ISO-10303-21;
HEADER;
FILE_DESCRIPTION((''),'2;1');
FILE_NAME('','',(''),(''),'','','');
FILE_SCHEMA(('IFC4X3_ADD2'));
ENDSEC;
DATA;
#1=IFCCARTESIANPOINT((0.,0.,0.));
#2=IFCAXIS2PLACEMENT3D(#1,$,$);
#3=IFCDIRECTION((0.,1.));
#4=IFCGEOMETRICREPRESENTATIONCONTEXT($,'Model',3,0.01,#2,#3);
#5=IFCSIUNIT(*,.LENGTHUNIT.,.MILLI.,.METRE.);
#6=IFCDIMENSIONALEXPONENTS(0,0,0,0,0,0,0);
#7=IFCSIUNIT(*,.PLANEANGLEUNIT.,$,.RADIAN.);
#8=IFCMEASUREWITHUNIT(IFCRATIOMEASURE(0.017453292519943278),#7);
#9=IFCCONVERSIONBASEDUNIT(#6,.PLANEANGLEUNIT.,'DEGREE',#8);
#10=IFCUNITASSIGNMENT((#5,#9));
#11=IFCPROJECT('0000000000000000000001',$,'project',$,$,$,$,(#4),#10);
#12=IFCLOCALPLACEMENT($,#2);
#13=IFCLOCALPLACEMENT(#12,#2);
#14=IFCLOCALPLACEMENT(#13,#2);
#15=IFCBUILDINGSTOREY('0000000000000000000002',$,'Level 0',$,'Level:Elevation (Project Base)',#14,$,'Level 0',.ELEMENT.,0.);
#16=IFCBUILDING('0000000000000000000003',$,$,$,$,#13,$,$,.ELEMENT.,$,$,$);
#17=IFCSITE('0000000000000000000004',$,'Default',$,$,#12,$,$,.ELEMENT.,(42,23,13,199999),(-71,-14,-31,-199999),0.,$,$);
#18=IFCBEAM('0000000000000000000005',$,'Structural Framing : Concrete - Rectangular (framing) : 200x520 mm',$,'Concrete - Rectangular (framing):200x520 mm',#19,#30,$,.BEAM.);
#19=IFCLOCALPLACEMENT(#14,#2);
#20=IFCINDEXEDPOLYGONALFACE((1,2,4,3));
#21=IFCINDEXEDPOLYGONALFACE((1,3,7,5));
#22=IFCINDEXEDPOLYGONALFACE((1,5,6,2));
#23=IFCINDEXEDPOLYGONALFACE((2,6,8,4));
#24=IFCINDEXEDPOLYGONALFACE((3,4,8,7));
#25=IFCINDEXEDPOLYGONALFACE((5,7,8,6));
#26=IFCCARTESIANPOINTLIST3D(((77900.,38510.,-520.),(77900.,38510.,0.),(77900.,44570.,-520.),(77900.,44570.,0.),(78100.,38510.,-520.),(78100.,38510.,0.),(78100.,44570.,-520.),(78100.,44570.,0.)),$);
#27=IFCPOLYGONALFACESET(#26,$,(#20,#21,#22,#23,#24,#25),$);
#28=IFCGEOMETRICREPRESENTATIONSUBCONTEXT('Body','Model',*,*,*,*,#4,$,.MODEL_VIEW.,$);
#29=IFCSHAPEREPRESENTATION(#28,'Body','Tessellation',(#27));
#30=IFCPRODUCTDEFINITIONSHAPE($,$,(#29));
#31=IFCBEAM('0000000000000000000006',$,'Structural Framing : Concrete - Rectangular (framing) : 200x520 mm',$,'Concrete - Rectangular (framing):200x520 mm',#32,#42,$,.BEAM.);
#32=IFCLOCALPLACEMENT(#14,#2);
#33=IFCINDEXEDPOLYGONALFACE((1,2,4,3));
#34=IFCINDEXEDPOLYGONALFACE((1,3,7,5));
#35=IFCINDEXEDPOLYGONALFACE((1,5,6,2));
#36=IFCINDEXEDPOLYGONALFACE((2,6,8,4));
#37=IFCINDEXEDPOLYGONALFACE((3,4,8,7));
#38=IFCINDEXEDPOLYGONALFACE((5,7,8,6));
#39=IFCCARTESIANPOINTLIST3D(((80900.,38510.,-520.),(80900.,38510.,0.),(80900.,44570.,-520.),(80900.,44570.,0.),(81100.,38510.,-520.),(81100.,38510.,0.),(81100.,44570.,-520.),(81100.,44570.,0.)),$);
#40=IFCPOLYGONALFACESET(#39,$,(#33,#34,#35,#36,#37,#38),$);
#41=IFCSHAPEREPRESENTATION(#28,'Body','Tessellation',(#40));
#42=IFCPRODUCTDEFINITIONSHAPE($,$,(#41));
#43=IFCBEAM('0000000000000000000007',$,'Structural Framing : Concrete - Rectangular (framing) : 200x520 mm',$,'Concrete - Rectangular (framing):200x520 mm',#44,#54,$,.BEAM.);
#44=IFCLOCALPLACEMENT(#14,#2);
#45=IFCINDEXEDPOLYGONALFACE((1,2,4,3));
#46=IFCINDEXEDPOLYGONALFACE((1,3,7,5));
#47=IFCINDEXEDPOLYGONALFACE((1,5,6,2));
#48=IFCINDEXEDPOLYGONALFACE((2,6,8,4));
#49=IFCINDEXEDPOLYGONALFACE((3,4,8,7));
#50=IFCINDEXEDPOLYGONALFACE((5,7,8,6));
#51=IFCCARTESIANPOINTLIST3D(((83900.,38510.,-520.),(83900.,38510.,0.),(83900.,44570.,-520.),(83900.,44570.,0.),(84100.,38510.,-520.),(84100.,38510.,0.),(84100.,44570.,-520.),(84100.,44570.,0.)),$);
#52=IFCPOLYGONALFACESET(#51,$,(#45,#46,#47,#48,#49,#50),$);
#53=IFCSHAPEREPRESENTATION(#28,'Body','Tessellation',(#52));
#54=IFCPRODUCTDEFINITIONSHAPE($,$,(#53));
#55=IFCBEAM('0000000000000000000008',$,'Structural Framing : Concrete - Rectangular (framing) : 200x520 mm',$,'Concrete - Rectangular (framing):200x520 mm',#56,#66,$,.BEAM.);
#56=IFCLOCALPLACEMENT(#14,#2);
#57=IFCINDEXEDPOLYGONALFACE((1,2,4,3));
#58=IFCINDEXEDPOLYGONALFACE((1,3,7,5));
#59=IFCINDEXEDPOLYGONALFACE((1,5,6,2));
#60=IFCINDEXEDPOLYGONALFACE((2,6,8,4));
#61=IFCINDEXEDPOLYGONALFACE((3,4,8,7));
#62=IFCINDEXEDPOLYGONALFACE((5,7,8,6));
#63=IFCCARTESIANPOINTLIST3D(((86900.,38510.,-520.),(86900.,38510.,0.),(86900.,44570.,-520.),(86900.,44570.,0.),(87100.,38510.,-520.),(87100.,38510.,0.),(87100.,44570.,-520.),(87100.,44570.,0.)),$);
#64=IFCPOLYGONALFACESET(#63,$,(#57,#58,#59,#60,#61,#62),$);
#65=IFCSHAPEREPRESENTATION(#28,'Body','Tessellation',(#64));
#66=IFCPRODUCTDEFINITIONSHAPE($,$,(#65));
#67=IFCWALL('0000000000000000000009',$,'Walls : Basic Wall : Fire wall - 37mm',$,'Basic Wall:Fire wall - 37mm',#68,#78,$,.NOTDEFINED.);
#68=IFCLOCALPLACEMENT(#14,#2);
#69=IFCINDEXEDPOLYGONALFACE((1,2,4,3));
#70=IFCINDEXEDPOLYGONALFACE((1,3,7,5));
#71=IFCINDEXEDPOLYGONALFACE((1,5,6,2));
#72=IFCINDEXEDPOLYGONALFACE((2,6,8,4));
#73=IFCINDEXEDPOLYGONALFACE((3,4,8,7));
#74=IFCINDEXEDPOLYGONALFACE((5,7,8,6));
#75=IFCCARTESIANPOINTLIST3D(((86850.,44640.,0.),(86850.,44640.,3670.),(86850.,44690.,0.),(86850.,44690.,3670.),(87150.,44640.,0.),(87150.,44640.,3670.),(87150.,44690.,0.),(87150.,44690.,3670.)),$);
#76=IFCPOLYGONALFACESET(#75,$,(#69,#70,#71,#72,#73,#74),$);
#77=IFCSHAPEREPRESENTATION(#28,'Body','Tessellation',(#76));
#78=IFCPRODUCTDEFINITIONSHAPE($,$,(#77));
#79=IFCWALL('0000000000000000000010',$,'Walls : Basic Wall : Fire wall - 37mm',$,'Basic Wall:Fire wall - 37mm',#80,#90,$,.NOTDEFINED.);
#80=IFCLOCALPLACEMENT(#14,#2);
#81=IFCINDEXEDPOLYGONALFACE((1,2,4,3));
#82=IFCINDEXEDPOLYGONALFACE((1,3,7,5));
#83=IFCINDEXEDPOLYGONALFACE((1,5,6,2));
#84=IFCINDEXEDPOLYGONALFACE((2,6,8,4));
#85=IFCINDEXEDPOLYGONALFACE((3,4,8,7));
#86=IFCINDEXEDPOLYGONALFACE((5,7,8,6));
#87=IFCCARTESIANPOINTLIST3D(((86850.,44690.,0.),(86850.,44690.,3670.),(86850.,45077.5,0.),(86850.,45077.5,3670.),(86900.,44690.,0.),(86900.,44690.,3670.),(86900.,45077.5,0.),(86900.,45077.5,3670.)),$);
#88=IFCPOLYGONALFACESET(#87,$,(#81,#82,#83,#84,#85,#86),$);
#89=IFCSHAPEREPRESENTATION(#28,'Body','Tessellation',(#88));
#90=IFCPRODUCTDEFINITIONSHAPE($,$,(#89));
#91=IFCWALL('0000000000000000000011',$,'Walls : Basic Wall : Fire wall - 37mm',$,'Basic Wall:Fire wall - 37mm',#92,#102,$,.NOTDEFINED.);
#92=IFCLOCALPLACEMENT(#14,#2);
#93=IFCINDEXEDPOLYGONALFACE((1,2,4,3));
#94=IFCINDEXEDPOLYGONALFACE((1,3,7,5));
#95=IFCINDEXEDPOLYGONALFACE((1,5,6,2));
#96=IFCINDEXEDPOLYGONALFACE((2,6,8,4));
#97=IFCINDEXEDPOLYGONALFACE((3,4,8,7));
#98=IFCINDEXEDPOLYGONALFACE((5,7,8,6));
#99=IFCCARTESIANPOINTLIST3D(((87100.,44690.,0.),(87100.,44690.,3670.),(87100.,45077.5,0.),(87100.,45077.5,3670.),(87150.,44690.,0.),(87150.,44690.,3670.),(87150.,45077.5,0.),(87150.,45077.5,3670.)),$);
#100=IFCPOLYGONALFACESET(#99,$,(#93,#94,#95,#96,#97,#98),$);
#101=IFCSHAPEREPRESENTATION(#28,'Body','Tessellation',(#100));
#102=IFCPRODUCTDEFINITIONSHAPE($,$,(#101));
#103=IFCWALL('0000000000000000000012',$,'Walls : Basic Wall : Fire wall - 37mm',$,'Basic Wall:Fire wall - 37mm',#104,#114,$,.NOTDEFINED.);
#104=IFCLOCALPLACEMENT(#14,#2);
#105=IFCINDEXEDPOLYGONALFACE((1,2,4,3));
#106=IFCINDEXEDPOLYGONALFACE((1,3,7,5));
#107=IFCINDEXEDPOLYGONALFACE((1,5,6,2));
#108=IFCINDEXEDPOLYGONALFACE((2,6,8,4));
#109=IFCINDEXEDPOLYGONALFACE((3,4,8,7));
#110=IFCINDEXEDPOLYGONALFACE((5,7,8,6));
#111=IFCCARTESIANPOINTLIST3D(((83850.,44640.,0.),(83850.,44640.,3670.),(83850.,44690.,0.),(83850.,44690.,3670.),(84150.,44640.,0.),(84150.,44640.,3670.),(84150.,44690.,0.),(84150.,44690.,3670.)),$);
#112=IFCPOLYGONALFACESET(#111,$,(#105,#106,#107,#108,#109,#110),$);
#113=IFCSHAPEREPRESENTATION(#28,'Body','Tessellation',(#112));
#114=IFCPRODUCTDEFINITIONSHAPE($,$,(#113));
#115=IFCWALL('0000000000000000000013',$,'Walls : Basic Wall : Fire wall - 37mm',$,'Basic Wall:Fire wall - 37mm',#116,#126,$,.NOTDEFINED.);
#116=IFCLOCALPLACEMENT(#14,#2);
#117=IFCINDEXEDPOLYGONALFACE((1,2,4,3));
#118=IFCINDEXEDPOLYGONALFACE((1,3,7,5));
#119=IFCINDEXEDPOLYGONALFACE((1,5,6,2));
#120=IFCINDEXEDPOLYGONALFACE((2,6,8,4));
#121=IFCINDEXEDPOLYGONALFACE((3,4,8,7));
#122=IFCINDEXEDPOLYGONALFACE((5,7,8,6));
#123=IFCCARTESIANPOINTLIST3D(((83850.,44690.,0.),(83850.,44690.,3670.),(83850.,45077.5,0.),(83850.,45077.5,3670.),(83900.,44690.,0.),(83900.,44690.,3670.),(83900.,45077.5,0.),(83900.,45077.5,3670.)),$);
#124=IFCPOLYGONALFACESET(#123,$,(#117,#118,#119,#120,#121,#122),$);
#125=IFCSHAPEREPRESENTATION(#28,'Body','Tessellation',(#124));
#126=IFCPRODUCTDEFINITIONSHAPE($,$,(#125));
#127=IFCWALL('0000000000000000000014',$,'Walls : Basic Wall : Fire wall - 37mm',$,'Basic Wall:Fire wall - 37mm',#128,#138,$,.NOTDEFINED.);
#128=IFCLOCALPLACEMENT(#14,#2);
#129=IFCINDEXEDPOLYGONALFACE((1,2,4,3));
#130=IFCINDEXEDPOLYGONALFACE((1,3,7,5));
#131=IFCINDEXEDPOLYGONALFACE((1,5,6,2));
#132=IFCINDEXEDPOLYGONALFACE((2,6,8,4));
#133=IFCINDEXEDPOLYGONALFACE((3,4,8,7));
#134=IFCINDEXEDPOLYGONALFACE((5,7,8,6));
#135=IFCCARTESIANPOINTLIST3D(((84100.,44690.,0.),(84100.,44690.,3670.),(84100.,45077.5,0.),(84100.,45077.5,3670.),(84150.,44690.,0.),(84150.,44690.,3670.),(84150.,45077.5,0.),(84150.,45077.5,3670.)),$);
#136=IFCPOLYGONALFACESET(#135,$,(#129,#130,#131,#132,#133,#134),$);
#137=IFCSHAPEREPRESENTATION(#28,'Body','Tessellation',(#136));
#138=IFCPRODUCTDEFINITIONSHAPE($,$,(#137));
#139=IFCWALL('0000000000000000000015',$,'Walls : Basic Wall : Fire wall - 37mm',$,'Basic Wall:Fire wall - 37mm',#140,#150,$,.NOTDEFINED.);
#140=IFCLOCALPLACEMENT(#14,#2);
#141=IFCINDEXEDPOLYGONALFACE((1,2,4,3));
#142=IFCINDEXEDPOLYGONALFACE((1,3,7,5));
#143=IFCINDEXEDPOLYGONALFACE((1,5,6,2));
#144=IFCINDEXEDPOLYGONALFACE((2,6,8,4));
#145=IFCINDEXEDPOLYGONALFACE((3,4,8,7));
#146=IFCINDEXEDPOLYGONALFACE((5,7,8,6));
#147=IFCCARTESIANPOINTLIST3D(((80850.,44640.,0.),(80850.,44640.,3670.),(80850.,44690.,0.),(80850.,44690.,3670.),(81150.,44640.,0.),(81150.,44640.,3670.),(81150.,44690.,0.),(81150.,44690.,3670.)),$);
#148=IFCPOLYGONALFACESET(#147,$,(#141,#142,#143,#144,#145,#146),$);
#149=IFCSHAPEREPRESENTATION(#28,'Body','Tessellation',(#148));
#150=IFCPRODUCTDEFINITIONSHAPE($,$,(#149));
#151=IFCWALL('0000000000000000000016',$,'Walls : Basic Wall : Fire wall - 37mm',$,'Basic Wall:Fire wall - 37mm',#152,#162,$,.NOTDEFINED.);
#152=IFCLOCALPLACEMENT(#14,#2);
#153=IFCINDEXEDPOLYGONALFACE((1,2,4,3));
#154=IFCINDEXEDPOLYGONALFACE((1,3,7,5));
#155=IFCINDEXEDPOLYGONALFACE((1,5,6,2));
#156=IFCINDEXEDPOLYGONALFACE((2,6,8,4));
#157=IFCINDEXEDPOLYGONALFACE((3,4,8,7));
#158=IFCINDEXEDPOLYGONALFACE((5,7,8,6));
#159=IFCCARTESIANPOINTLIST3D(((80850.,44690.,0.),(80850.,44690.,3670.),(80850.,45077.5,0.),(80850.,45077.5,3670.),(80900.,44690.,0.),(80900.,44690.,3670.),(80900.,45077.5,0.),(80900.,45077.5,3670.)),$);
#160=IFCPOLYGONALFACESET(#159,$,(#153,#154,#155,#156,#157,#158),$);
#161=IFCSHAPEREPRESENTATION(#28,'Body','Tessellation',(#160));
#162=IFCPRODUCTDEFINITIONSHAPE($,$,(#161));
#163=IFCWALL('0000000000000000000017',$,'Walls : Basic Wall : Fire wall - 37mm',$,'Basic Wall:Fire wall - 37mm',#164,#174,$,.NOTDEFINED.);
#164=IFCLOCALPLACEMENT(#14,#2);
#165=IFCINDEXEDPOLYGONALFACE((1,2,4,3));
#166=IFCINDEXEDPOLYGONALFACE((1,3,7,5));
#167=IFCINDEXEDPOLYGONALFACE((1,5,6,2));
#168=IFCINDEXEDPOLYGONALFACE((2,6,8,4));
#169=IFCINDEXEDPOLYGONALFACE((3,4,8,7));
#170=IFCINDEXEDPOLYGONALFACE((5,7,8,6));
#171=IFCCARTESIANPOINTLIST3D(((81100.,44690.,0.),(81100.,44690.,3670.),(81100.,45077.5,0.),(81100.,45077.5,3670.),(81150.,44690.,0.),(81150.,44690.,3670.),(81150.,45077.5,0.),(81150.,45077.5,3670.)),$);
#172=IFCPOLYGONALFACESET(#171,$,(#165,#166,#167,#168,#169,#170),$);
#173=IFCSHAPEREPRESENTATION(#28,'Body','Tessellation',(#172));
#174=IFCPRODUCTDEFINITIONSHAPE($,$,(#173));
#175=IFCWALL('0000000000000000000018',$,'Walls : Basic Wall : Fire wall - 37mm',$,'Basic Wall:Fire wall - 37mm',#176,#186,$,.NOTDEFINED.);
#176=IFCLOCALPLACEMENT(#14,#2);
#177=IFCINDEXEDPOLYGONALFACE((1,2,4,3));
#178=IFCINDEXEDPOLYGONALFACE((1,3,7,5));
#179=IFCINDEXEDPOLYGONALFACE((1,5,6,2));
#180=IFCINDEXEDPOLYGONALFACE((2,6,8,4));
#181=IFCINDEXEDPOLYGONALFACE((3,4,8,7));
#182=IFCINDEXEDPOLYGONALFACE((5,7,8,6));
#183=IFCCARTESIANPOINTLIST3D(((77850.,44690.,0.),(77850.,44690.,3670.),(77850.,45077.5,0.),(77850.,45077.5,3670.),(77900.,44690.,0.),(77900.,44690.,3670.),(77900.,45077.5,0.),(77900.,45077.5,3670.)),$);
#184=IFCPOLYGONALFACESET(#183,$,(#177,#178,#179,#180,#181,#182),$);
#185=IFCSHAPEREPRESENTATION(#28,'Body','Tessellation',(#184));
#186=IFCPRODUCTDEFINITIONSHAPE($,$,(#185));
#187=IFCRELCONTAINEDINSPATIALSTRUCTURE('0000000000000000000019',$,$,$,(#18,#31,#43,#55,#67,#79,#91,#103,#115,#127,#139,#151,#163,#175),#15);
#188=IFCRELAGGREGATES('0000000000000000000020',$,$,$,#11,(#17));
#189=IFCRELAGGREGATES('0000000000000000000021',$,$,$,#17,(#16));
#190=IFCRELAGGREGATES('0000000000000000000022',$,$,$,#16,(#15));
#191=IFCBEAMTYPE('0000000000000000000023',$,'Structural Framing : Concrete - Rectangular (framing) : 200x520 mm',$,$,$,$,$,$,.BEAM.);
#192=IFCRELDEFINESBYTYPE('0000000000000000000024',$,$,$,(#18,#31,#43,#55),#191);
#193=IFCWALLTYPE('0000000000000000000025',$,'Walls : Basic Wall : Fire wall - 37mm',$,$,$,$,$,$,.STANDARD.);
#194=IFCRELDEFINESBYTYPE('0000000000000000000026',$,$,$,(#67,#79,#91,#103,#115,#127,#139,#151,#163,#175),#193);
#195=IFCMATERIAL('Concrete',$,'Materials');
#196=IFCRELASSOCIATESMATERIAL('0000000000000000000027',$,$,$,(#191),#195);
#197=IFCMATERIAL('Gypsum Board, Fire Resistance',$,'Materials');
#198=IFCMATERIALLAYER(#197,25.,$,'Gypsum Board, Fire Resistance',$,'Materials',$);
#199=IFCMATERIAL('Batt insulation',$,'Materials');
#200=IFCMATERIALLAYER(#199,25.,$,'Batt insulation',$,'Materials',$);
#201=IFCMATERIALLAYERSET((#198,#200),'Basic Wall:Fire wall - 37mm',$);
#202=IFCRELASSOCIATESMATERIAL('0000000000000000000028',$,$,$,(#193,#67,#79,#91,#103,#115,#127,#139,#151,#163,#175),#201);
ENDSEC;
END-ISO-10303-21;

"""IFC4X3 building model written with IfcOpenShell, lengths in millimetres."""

from ifc_helpers import new_model, entity, si_unit, converted_unit, direction, frame, frame_2d, origin, place, context, subcontext, project, spatial, rectangle, extrude, source, transform, mapped, material, layer, layer_set, material_profile, profile_set, type_object, type_shapes, element, save


model = new_model("IFC4X3")

# Units and contexts
model_context = context("Model", 3, precision=0.01, world=origin(), true_north=direction((0.0, 1.0)))
body_context = subcontext(model_context, "Body", "Model", "MODEL_VIEW")
ifc_project = project(units=[si_unit("LENGTHUNIT", "METRE", prefix="MILLI"), converted_unit("PLANEANGLEUNIT", "DEGREE", entity("IfcRatioMeasure", 0.017453292519943278), si_unit("PLANEANGLEUNIT", "RADIAN"), dimensions=[0, 0, 0, 0, 0, 0, 0])], contexts=[model_context])

# Site, building, storey
site_placement = place(None, origin())
site = spatial("IfcSite", under=ifc_project, at=site_placement, Name="Default", CompositionType="ELEMENT", RefLatitude=(42, 23, 13, 199999), RefLongitude=(-71, -14, -31, -199999), RefElevation=0.0)
building_placement = place(site_placement, origin())
building = spatial("IfcBuilding", under=site, at=building_placement, CompositionType="ELEMENT")
storey_placement = place(building_placement, origin())
storey = spatial("IfcBuildingStorey", under=building, at=storey_placement, Name="Level 0", ObjectType="Level:Elevation (Project Base)", LongName="Level 0", CompositionType="ELEMENT", Elevation=0.0)

# Beams
ifc_material_1 = material(Name="Concrete", Category="Materials")
ifc_material_profile = material_profile(ifc_material_1, rectangle(XDim=520.0, YDim=200.0, at=frame_2d((0.0, 0.0), x_axis=(1.0, 0.0))), Name="200x520 mm")
ifc_profile_set = profile_set([ifc_material_profile], Name="200x520 mm")
beam_type = type_object("IfcBeamType", Name="Structural Framing : Concrete - Rectangular (framing) : 200x520 mm", PredefinedType="BEAM", material=ifc_profile_set)
shared_shape = source(origin(), body_context, "Body", "SweptSolid", [
    extrude(rectangle(XDim=520.0, YDim=200.0, at=frame_2d((0.0, 0.0), x_axis=(1.0, 0.0))), frame((-1230.0, 0.0, 0.0), z_axis=(1.0, 0.0, 0.0), x_axis=(0.0, 0.0, -1.0)), (0.0, 0.0, 1.0), 6060.0),
])
type_shapes(beam_type, [shared_shape])
for number, where, z_axis, x_axis, name in (
    (1, (78000.0, 43340.0, -260.0), (0.0, 0.0, 1.0), (0.0, -1.0, 0.0), "Structural Framing : Concrete - Rectangular (framing) : 200x520 mm"),
    (2, (81000.0, 43340.0, -260.0), (0.0, 0.0, 1.0), (0.0, -1.0, 0.0), "Structural Framing : Concrete - Rectangular (framing) : 200x520 mm"),
    (3, (84000.0, 43340.0, -260.0), (0.0, 0.0, 1.0), (0.0, -1.0, 0.0), "Structural Framing : Concrete - Rectangular (framing) : 200x520 mm"),
    (4, (87000.0, 43340.0, -260.0), (0.0, 0.0, 1.0), (0.0, -1.0, 0.0), "Structural Framing : Concrete - Rectangular (framing) : 200x520 mm"),
):
    element("IfcBeam", number, at=place(storey_placement, frame(where, z_axis=z_axis, x_axis=x_axis)), inside=storey, type_object=beam_type, Name=name, ObjectType="Concrete - Rectangular (framing):200x520 mm", PredefinedType="BEAM", context=body_context, shape_type="MappedRepresentation", body=[
        mapped(shared_shape, transform((0.0, 0.0, 0.0), scale=1.0)),
    ])

# Walls
ifc_material_2 = material(Name="Gypsum Board, Fire Resistance", Category="Materials")
ifc_layer_1 = layer(ifc_material_2, 25.0, Name="Gypsum Board, Fire Resistance", Category="Materials")
ifc_material_3 = material(Name="Batt insulation", Category="Materials")
ifc_layer_2 = layer(ifc_material_3, 25.0, Name="Batt insulation", Category="Materials")
ifc_layer_set = layer_set([ifc_layer_1, ifc_layer_2], Name="Basic Wall:Fire wall - 37mm")
wall_type = type_object("IfcWallType", Name="Walls : Basic Wall : Fire wall - 37mm", PredefinedType="STANDARD", material=ifc_layer_set)
wall_1_placement = place(storey_placement, frame((86850.0, 44665.0, 0.0)))
element("IfcWall", 5, at=wall_1_placement, inside=storey, type_object=wall_type, material=ifc_layer_set, Name="Walls : Basic Wall : Fire wall - 37mm", ObjectType="Basic Wall:Fire wall - 37mm", PredefinedType="NOTDEFINED", context=body_context, shape_type="SweptSolid", body=[
    extrude(rectangle(XDim=300.0, YDim=50.0, at=frame_2d((150.0, 0.0), x_axis=(-1.0, 0.0))), origin(), (0.0, 0.0, 1.0), 3670.0),
])
wall_2_placement = place(storey_placement, frame((86875.0, 45077.5, 0.0), z_axis=(0.0, 0.0, 1.0), x_axis=(0.0, -1.0, 0.0)))
element("IfcWall", 6, at=wall_2_placement, inside=storey, type_object=wall_type, material=ifc_layer_set, Name="Walls : Basic Wall : Fire wall - 37mm", ObjectType="Basic Wall:Fire wall - 37mm", PredefinedType="NOTDEFINED", context=body_context, shape_type="SweptSolid", body=[
    extrude(rectangle(XDim=387.5, YDim=50.0, at=frame_2d((193.7, 0.0), x_axis=(-1.0, 0.0))), origin(), (0.0, 0.0, 1.0), 3670.0),
])
wall_3_placement = place(storey_placement, frame((87125.0, 45077.5, 0.0), z_axis=(0.0, 0.0, 1.0), x_axis=(0.0, -1.0, 0.0)))
element("IfcWall", 7, at=wall_3_placement, inside=storey, type_object=wall_type, material=ifc_layer_set, Name="Walls : Basic Wall : Fire wall - 37mm", ObjectType="Basic Wall:Fire wall - 37mm", PredefinedType="NOTDEFINED", context=body_context, shape_type="SweptSolid", body=[
    extrude(rectangle(XDim=387.5, YDim=50.0, at=frame_2d((193.7, 0.0), x_axis=(-1.0, 0.0))), origin(), (0.0, 0.0, 1.0), 3670.0),
])
wall_4_placement = place(storey_placement, frame((83850.0, 44665.0, 0.0)))
element("IfcWall", 8, at=wall_4_placement, inside=storey, type_object=wall_type, material=ifc_layer_set, Name="Walls : Basic Wall : Fire wall - 37mm", ObjectType="Basic Wall:Fire wall - 37mm", PredefinedType="NOTDEFINED", context=body_context, shape_type="SweptSolid", body=[
    extrude(rectangle(XDim=300.0, YDim=50.0, at=frame_2d((150.0, 0.0), x_axis=(-1.0, 0.0))), origin(), (0.0, 0.0, 1.0), 3670.0),
])
for number, where, z_axis, x_axis, name in (
    (9, (83875.0, 45077.5, 0.0), (0.0, 0.0, 1.0), (0.0, -1.0, 0.0), "Walls : Basic Wall : Fire wall - 37mm"),
    (10, (84125.0, 45077.5, 0.0), (0.0, 0.0, 1.0), (0.0, -1.0, 0.0), "Walls : Basic Wall : Fire wall - 37mm"),
):
    element("IfcWall", number, at=place(storey_placement, frame(where, z_axis=z_axis, x_axis=x_axis)), inside=storey, type_object=wall_type, material=ifc_layer_set, Name=name, ObjectType="Basic Wall:Fire wall - 37mm", PredefinedType="NOTDEFINED", context=body_context, shape_type="SweptSolid", body=[
        extrude(rectangle(XDim=387.5, YDim=50.0, at=frame_2d((193.7, 0.0), x_axis=(-1.0, 0.0))), origin(), (0.0, 0.0, 1.0), 3670.0),
    ])
wall_5_placement = place(storey_placement, frame((80850.0, 44665.0, 0.0)))
element("IfcWall", 11, at=wall_5_placement, inside=storey, type_object=wall_type, material=ifc_layer_set, Name="Walls : Basic Wall : Fire wall - 37mm", ObjectType="Basic Wall:Fire wall - 37mm", PredefinedType="NOTDEFINED", context=body_context, shape_type="SweptSolid", body=[
    extrude(rectangle(XDim=300.0, YDim=50.0, at=frame_2d((150.0, 0.0), x_axis=(-1.0, 0.0))), origin(), (0.0, 0.0, 1.0), 3670.0),
])
wall_6_placement = place(storey_placement, frame((80875.0, 45077.5, 0.0), z_axis=(0.0, 0.0, 1.0), x_axis=(0.0, -1.0, 0.0)))
element("IfcWall", 12, at=wall_6_placement, inside=storey, type_object=wall_type, material=ifc_layer_set, Name="Walls : Basic Wall : Fire wall - 37mm", ObjectType="Basic Wall:Fire wall - 37mm", PredefinedType="NOTDEFINED", context=body_context, shape_type="SweptSolid", body=[
    extrude(rectangle(XDim=387.5, YDim=50.0, at=frame_2d((193.7, 0.0), x_axis=(-1.0, 0.0))), origin(), (0.0, 0.0, 1.0), 3670.0),
])
wall_7_placement = place(storey_placement, frame((81125.0, 45077.5, 0.0), z_axis=(0.0, 0.0, 1.0), x_axis=(0.0, -1.0, 0.0)))
element("IfcWall", 13, at=wall_7_placement, inside=storey, type_object=wall_type, material=ifc_layer_set, Name="Walls : Basic Wall : Fire wall - 37mm", ObjectType="Basic Wall:Fire wall - 37mm", PredefinedType="NOTDEFINED", context=body_context, shape_type="SweptSolid", body=[
    extrude(rectangle(XDim=387.5, YDim=50.0, at=frame_2d((193.7, 0.0), x_axis=(-1.0, 0.0))), origin(), (0.0, 0.0, 1.0), 3670.0),
])
wall_8_placement = place(storey_placement, frame((77875.0, 45077.5, 0.0), z_axis=(0.0, 0.0, 1.0), x_axis=(0.0, -1.0, 0.0)))
element("IfcWall", 14, at=wall_8_placement, inside=storey, type_object=wall_type, material=ifc_layer_set, Name="Walls : Basic Wall : Fire wall - 37mm", ObjectType="Basic Wall:Fire wall - 37mm", PredefinedType="NOTDEFINED", context=body_context, shape_type="SweptSolid", body=[
    extrude(rectangle(XDim=387.5, YDim=50.0, at=frame_2d((193.7, 0.0), x_axis=(-1.0, 0.0))), origin(), (0.0, 0.0, 1.0), 3670.0),
])

save(model, "model.ifc")
